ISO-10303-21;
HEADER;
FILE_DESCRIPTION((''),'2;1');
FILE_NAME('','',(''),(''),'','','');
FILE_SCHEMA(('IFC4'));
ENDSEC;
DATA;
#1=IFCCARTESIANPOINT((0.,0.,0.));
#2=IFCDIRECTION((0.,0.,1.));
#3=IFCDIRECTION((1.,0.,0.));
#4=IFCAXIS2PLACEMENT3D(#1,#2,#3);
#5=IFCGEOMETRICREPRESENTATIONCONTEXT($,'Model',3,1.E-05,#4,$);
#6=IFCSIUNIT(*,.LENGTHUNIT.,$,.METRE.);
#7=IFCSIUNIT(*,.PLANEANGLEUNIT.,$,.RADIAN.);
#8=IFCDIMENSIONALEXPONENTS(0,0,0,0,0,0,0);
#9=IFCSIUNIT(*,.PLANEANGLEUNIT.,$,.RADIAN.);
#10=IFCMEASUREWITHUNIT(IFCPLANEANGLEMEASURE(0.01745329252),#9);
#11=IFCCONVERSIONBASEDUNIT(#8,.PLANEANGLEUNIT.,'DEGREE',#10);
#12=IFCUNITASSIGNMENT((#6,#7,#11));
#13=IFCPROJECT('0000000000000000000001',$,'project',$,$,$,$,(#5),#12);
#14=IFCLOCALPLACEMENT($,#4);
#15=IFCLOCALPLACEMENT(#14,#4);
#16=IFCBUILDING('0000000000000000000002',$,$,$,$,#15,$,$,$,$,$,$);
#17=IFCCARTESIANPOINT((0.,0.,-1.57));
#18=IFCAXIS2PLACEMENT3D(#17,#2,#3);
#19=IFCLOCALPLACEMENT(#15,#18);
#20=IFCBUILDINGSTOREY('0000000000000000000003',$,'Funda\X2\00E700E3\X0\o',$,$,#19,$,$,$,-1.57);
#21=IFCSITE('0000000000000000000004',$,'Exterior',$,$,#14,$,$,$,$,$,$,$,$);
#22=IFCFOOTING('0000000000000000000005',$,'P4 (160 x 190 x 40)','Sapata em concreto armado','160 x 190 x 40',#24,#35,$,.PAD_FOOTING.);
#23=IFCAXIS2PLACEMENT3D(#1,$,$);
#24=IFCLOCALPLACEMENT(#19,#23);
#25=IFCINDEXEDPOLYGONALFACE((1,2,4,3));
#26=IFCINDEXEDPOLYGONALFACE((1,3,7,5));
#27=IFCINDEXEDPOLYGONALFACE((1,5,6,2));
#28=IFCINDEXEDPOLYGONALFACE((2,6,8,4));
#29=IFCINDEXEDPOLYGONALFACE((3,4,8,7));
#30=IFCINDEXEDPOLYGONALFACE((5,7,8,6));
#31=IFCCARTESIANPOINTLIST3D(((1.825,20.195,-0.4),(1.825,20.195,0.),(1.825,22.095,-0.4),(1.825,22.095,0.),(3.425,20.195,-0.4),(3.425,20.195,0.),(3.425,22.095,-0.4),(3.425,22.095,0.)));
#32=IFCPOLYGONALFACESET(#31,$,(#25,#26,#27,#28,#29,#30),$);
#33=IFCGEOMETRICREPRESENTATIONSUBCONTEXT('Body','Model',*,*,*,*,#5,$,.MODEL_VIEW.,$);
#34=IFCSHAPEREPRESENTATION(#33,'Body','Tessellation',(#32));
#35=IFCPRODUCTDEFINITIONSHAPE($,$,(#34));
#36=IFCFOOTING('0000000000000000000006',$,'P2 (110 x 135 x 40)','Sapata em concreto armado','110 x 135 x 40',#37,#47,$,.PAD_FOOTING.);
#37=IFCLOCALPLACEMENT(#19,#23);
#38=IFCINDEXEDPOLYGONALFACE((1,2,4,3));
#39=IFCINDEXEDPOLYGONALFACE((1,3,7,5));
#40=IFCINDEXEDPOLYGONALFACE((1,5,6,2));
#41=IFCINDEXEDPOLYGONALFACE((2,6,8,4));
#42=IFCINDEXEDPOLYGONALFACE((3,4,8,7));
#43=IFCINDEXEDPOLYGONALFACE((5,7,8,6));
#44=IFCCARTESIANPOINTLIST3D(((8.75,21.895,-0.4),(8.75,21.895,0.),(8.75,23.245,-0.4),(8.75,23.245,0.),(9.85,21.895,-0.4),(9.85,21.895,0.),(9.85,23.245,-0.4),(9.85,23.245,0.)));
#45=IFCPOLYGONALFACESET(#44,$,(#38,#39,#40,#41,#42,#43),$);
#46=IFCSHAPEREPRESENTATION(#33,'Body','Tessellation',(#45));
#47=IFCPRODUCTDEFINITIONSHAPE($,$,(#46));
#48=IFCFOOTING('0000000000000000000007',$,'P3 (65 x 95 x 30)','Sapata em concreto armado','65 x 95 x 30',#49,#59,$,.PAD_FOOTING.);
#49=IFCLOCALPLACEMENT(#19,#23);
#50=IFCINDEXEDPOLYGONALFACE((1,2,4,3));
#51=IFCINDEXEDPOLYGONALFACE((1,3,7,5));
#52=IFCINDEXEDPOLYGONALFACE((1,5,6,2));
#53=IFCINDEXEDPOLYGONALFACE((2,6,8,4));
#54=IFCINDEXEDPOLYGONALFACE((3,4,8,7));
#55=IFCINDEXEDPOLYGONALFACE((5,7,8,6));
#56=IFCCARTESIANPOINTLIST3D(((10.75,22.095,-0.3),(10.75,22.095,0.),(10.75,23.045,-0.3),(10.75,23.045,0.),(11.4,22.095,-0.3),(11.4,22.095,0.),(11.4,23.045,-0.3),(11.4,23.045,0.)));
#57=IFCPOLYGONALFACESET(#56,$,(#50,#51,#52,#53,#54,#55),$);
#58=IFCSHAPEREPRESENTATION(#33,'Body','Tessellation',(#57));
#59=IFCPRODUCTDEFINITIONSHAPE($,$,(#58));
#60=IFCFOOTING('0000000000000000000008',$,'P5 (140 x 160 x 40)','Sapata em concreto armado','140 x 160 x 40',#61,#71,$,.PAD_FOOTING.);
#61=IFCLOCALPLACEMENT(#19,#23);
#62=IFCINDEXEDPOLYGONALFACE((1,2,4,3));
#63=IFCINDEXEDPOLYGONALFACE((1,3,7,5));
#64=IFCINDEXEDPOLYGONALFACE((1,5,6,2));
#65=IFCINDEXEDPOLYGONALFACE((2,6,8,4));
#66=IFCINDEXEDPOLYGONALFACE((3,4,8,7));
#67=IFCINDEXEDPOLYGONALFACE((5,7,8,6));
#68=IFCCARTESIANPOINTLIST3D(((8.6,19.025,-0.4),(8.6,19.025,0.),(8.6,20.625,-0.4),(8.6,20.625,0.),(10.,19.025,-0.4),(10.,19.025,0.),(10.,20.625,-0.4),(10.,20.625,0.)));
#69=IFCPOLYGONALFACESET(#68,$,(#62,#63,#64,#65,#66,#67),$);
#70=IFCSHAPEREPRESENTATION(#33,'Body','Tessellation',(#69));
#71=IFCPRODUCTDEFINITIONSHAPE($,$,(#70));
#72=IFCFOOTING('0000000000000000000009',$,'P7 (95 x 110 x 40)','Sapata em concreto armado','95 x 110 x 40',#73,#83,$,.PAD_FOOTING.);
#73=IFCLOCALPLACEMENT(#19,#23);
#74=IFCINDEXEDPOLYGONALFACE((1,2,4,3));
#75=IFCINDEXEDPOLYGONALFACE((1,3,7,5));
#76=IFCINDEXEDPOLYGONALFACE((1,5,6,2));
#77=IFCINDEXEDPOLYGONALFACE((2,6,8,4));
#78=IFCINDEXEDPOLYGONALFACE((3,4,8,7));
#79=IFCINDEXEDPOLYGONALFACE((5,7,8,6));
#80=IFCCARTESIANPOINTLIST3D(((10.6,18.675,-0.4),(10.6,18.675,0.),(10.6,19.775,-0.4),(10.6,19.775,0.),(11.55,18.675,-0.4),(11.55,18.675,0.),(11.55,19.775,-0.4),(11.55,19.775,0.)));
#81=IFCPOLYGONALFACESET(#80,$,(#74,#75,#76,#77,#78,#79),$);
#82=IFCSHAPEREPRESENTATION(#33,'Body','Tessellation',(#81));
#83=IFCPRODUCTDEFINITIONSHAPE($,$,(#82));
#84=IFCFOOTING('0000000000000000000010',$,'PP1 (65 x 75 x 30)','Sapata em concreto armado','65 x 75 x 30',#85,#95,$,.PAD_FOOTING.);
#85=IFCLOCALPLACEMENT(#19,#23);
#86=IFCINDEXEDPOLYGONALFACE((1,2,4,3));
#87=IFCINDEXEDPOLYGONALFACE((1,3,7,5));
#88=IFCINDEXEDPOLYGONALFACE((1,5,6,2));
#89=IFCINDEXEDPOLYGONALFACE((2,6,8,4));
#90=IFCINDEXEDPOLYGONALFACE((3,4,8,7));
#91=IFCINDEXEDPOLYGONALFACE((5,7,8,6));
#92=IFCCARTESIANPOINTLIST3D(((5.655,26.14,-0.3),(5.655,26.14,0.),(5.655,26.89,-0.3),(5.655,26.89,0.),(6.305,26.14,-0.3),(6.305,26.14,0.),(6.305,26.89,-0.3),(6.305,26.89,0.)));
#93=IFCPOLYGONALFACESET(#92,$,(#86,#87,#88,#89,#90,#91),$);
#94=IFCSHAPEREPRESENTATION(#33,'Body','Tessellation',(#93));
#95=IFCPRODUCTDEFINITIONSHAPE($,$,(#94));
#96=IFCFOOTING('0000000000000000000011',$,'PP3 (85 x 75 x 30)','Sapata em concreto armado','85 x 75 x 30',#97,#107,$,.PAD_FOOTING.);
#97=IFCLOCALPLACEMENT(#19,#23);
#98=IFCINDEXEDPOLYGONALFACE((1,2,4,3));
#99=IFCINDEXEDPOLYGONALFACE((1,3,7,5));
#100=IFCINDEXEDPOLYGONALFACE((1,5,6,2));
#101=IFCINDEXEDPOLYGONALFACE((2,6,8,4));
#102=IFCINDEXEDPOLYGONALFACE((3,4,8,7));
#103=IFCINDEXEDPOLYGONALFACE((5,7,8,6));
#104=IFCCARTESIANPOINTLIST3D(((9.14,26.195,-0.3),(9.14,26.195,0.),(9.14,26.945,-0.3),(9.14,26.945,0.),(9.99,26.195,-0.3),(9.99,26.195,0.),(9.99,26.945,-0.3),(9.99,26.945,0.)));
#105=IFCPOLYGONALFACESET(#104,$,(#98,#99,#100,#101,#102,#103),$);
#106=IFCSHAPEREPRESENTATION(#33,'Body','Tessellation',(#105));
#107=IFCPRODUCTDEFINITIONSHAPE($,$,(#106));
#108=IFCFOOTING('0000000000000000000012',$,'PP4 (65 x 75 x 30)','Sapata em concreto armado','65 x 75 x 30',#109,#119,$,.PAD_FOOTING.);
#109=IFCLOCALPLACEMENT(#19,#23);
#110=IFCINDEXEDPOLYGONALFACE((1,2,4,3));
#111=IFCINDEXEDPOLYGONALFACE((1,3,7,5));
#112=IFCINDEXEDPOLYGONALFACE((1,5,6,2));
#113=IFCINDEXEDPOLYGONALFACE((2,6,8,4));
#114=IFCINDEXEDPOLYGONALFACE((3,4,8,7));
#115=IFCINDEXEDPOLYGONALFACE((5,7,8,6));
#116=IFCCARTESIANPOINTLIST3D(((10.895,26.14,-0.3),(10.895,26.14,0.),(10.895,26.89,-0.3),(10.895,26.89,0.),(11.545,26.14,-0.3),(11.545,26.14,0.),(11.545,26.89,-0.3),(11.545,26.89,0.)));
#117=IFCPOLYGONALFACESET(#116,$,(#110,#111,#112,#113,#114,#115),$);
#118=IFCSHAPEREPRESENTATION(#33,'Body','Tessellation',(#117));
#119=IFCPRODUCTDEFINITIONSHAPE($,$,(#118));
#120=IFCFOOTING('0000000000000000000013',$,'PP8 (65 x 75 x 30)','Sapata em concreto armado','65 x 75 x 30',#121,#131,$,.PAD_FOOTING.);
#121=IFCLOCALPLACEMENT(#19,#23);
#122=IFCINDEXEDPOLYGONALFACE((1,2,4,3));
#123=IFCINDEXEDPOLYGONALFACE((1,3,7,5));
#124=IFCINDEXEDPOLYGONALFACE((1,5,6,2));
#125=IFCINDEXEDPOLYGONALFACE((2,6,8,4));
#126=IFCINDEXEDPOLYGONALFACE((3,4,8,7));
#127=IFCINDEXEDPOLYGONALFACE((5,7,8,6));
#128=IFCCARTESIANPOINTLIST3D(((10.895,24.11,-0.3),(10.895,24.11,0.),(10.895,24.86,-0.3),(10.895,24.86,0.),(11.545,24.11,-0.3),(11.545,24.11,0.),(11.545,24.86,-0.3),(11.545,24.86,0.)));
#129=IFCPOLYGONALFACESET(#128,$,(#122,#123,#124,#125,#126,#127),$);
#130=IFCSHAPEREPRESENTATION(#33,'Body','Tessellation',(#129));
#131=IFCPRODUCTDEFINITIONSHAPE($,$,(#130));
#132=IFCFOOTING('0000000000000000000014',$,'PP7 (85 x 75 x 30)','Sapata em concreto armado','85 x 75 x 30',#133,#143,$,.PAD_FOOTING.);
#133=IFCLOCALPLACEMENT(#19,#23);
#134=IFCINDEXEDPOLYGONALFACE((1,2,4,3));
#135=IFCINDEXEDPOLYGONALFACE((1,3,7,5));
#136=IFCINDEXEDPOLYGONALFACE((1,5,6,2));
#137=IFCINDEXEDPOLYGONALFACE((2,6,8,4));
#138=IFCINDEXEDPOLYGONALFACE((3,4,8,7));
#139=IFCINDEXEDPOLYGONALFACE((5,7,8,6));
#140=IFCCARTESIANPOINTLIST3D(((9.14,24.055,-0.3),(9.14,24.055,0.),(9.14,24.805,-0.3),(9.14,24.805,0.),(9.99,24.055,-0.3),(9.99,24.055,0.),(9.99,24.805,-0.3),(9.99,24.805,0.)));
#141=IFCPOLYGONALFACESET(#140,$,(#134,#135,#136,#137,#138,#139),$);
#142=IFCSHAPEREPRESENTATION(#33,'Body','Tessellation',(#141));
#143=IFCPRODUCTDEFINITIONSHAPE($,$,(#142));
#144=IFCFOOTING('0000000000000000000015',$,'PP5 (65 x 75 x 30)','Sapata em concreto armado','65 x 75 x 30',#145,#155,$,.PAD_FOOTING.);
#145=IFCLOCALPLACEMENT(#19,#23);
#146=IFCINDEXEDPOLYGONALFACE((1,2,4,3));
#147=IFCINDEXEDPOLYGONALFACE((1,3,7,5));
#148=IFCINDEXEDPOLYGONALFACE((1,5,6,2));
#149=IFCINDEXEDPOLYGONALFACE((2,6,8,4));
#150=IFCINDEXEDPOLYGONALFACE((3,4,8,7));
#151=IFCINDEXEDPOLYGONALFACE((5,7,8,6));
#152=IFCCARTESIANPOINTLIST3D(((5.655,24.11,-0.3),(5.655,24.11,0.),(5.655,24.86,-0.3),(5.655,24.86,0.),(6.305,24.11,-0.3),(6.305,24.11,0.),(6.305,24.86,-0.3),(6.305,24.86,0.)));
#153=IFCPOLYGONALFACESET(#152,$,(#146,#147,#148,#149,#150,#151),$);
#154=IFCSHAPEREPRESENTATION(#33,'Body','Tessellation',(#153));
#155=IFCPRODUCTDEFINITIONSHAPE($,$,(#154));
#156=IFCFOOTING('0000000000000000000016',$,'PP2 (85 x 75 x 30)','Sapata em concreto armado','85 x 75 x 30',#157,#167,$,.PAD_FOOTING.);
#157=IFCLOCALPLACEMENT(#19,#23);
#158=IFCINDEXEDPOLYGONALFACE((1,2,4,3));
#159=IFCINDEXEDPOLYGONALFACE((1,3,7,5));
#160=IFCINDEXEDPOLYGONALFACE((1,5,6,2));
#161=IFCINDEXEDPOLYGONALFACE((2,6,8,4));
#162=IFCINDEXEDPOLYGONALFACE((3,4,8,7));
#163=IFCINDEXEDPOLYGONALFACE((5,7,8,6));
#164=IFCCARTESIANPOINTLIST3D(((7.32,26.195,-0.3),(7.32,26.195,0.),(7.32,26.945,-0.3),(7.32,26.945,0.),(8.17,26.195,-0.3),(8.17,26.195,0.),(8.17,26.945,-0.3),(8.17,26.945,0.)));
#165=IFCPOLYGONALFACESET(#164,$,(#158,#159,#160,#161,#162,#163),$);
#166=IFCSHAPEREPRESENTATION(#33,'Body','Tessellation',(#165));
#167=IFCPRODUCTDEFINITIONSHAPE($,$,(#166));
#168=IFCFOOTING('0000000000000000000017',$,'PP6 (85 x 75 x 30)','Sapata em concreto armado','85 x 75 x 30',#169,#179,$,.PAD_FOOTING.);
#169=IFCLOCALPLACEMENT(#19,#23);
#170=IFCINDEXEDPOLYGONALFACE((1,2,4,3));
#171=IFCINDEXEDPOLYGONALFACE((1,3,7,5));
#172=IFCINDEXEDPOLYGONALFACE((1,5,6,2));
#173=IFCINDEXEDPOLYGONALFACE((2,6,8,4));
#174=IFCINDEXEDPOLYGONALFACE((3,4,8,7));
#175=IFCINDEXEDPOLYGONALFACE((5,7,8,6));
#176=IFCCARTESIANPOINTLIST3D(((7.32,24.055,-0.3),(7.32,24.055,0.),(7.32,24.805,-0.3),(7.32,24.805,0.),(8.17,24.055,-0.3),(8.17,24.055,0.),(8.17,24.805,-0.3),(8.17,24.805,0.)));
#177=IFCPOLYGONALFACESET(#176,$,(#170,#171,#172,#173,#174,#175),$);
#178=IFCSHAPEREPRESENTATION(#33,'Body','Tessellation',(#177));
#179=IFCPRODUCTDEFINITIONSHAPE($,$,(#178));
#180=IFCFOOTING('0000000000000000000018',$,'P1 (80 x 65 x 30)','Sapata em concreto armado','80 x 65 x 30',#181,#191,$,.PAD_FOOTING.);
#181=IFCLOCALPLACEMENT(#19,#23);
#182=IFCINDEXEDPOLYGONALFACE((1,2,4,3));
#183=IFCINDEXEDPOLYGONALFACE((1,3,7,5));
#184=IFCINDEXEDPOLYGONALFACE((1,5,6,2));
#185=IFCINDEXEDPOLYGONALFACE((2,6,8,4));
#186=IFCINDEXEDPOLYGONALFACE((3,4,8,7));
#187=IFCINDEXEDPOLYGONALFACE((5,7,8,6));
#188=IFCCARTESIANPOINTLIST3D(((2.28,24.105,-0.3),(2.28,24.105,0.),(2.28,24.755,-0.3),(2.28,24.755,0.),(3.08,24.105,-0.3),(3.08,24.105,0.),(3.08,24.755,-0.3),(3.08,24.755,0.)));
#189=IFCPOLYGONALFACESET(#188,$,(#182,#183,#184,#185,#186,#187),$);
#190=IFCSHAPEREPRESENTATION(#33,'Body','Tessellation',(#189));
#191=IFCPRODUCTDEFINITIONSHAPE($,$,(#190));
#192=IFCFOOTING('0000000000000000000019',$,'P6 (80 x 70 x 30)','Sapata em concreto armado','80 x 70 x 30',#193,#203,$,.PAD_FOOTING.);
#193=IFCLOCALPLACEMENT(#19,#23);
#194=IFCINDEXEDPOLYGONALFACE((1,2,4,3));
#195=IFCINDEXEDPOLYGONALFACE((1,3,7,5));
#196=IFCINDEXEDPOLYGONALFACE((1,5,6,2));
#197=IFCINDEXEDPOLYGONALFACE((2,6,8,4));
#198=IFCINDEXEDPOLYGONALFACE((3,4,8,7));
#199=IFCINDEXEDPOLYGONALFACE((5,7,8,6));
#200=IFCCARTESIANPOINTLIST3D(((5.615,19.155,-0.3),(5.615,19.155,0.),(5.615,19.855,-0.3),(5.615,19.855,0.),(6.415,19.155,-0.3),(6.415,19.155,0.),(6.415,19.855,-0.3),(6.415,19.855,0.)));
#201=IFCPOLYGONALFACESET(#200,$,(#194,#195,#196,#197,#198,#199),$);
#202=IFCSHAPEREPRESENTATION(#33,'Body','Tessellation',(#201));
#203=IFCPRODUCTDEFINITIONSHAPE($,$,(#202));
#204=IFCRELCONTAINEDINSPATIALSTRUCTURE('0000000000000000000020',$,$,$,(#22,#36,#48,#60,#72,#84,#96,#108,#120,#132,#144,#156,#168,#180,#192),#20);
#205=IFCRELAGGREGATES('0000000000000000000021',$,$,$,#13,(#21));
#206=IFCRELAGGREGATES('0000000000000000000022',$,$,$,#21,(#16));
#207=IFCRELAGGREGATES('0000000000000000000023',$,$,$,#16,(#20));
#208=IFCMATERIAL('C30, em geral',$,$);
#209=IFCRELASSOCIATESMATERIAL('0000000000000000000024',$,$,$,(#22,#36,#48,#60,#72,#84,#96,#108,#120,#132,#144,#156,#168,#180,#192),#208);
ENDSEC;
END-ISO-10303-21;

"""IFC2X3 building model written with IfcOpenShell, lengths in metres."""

from ifc_helpers import new_model, entity, si_unit, converted_unit, frame, origin_with_axes, origin_2d_with_axis, place, context, subcontext, project, spatial, rectangle, extrude, material, element, save


model = new_model("IFC2X3")

# Units and contexts
model_context = context("Model", 3, precision=1e-05, world=origin_with_axes())
body_context = subcontext(model_context, "Body", "Model", "MODEL_VIEW")
ifc_project = project(units=[si_unit("LENGTHUNIT", "METRE"), si_unit("PLANEANGLEUNIT", "RADIAN"), converted_unit("PLANEANGLEUNIT", "DEGREE", entity("IfcPlaneAngleMeasure", 0.01745329252), si_unit("PLANEANGLEUNIT", "RADIAN"), dimensions=[0, 0, 0, 0, 0, 0, 0])], contexts=[model_context])

# Site, building, storey
site_placement = place(None, origin_with_axes())
site = spatial("IfcSite", under=ifc_project, at=site_placement, Name="Exterior")
building_placement = place(site_placement, origin_with_axes())
building = spatial("IfcBuilding", under=site, at=building_placement)
storey_placement = place(building_placement, frame((0.0, 0.0, -1.57), z_axis=(0.0, 0.0, 1.0), x_axis=(1.0, 0.0, 0.0)))
storey = spatial("IfcBuildingStorey", under=building, at=storey_placement, Name="Fundação", Elevation=-1.57)

# Footings
ifc_material_1 = material(Name="C30, em geral")
footing_1_placement = place(storey_placement, frame((2.625, 21.145, -0.4), z_axis=(0.0, 0.0, 1.0), x_axis=(1.0, 0.0, 0.0)))
element("IfcFooting", 1, at=footing_1_placement, inside=storey, material=ifc_material_1, Name="P4 (160 x 190 x 40)", Description="Sapata em concreto armado", ObjectType="160 x 190 x 40", PredefinedType="PAD_FOOTING", context=body_context, shape_type="SweptSolid", body=[
    extrude(rectangle(XDim=1.6, YDim=1.9, at=origin_2d_with_axis()), origin_with_axes(), (0.0, 0.0, 1.0), 0.4),
])
footing_2_placement = place(storey_placement, frame((9.3, 22.57, -0.4), z_axis=(0.0, 0.0, 1.0), x_axis=(1.0, 0.0, 0.0)))
element("IfcFooting", 2, at=footing_2_placement, inside=storey, material=ifc_material_1, Name="P2 (110 x 135 x 40)", Description="Sapata em concreto armado", ObjectType="110 x 135 x 40", PredefinedType="PAD_FOOTING", context=body_context, shape_type="SweptSolid", body=[
    extrude(rectangle(XDim=1.1, YDim=1.35, at=origin_2d_with_axis()), origin_with_axes(), (0.0, 0.0, 1.0), 0.4),
])
footing_3_placement = place(storey_placement, frame((11.075, 22.57, -0.3), z_axis=(0.0, 0.0, 1.0), x_axis=(1.0, 0.0, 0.0)))
element("IfcFooting", 3, at=footing_3_placement, inside=storey, material=ifc_material_1, Name="P3 (65 x 95 x 30)", Description="Sapata em concreto armado", ObjectType="65 x 95 x 30", PredefinedType="PAD_FOOTING", context=body_context, shape_type="SweptSolid", body=[
    extrude(rectangle(XDim=0.65, YDim=0.95, at=origin_2d_with_axis()), origin_with_axes(), (0.0, 0.0, 1.0), 0.3),
])
footing_4_placement = place(storey_placement, frame((9.3, 19.825, -0.4), z_axis=(0.0, 0.0, 1.0), x_axis=(1.0, 0.0, 0.0)))
element("IfcFooting", 4, at=footing_4_placement, inside=storey, material=ifc_material_1, Name="P5 (140 x 160 x 40)", Description="Sapata em concreto armado", ObjectType="140 x 160 x 40", PredefinedType="PAD_FOOTING", context=body_context, shape_type="SweptSolid", body=[
    extrude(rectangle(XDim=1.4, YDim=1.6, at=origin_2d_with_axis()), origin_with_axes(), (0.0, 0.0, 1.0), 0.4),
])
footing_5_placement = place(storey_placement, frame((11.075, 19.225, -0.4), z_axis=(0.0, 0.0, 1.0), x_axis=(1.0, 0.0, 0.0)))
element("IfcFooting", 5, at=footing_5_placement, inside=storey, material=ifc_material_1, Name="P7 (95 x 110 x 40)", Description="Sapata em concreto armado", ObjectType="95 x 110 x 40", PredefinedType="PAD_FOOTING", context=body_context, shape_type="SweptSolid", body=[
    extrude(rectangle(XDim=0.95, YDim=1.1, at=origin_2d_with_axis()), origin_with_axes(), (0.0, 0.0, 1.0), 0.4),
])
footing_6_placement = place(storey_placement, frame((5.98, 26.515, -0.3), z_axis=(0.0, 0.0, 1.0), x_axis=(1.0, 0.0, 0.0)))
element("IfcFooting", 6, at=footing_6_placement, inside=storey, material=ifc_material_1, Name="PP1 (65 x 75 x 30)", Description="Sapata em concreto armado", ObjectType="65 x 75 x 30", PredefinedType="PAD_FOOTING", context=body_context, shape_type="SweptSolid", body=[
    extrude(rectangle(XDim=0.65, YDim=0.75, at=origin_2d_with_axis()), origin_with_axes(), (0.0, 0.0, 1.0), 0.3),
])
footing_7_placement = place(storey_placement, frame((9.565, 26.57, -0.3), z_axis=(0.0, 0.0, 1.0), x_axis=(1.0, 0.0, 0.0)))
element("IfcFooting", 7, at=footing_7_placement, inside=storey, material=ifc_material_1, Name="PP3 (85 x 75 x 30)", Description="Sapata em concreto armado", ObjectType="85 x 75 x 30", PredefinedType="PAD_FOOTING", context=body_context, shape_type="SweptSolid", body=[
    extrude(rectangle(XDim=0.85, YDim=0.75, at=origin_2d_with_axis()), origin_with_axes(), (0.0, 0.0, 1.0), 0.3),
])
for number, where, z_axis, x_axis, name in (
    (8, (11.22, 26.515, -0.3), (0.0, 0.0, 1.0), (1.0, 0.0, 0.0), "PP4 (65 x 75 x 30)"),
    (9, (11.22, 24.485, -0.3), (0.0, 0.0, 1.0), (1.0, 0.0, 0.0), "PP8 (65 x 75 x 30)"),
):
    element("IfcFooting", number, at=place(storey_placement, frame(where, z_axis=z_axis, x_axis=x_axis)), inside=storey, material=ifc_material_1, Name=name, Description="Sapata em concreto armado", ObjectType="65 x 75 x 30", PredefinedType="PAD_FOOTING", context=body_context, shape_type="SweptSolid", body=[
        extrude(rectangle(XDim=0.65, YDim=0.75, at=origin_2d_with_axis()), origin_with_axes(), (0.0, 0.0, 1.0), 0.3),
    ])
footing_8_placement = place(storey_placement, frame((9.565, 24.43, -0.3), z_axis=(0.0, 0.0, 1.0), x_axis=(1.0, 0.0, 0.0)))
element("IfcFooting", 10, at=footing_8_placement, inside=storey, material=ifc_material_1, Name="PP7 (85 x 75 x 30)", Description="Sapata em concreto armado", ObjectType="85 x 75 x 30", PredefinedType="PAD_FOOTING", context=body_context, shape_type="SweptSolid", body=[
    extrude(rectangle(XDim=0.85, YDim=0.75, at=origin_2d_with_axis()), origin_with_axes(), (0.0, 0.0, 1.0), 0.3),
])
footing_9_placement = place(storey_placement, frame((5.98, 24.485, -0.3), z_axis=(0.0, 0.0, 1.0), x_axis=(1.0, 0.0, 0.0)))
element("IfcFooting", 11, at=footing_9_placement, inside=storey, material=ifc_material_1, Name="PP5 (65 x 75 x 30)", Description="Sapata em concreto armado", ObjectType="65 x 75 x 30", PredefinedType="PAD_FOOTING", context=body_context, shape_type="SweptSolid", body=[
    extrude(rectangle(XDim=0.65, YDim=0.75, at=origin_2d_with_axis()), origin_with_axes(), (0.0, 0.0, 1.0), 0.3),
])
for number, where, z_axis, x_axis, name in (
    (12, (7.745, 26.57, -0.3), (0.0, 0.0, 1.0), (1.0, 0.0, 0.0), "PP2 (85 x 75 x 30)"),
    (13, (7.745, 24.43, -0.3), (0.0, 0.0, 1.0), (1.0, 0.0, 0.0), "PP6 (85 x 75 x 30)"),
):
    element("IfcFooting", number, at=place(storey_placement, frame(where, z_axis=z_axis, x_axis=x_axis)), inside=storey, material=ifc_material_1, Name=name, Description="Sapata em concreto armado", ObjectType="85 x 75 x 30", PredefinedType="PAD_FOOTING", context=body_context, shape_type="SweptSolid", body=[
        extrude(rectangle(XDim=0.85, YDim=0.75, at=origin_2d_with_axis()), origin_with_axes(), (0.0, 0.0, 1.0), 0.3),
    ])
footing_10_placement = place(storey_placement, frame((2.68, 24.43, -0.3), z_axis=(0.0, 0.0, 1.0), x_axis=(1.0, 0.0, 0.0)))
element("IfcFooting", 14, at=footing_10_placement, inside=storey, material=ifc_material_1, Name="P1 (80 x 65 x 30)", Description="Sapata em concreto armado", ObjectType="80 x 65 x 30", PredefinedType="PAD_FOOTING", context=body_context, shape_type="SweptSolid", body=[
    extrude(rectangle(XDim=0.8, YDim=0.65, at=origin_2d_with_axis()), origin_with_axes(), (0.0, 0.0, 1.0), 0.3),
])
footing_11_placement = place(storey_placement, frame((6.015, 19.505, -0.3), z_axis=(0.0, 0.0, 1.0), x_axis=(1.0, 0.0, 0.0)))
element("IfcFooting", 15, at=footing_11_placement, inside=storey, material=ifc_material_1, Name="P6 (80 x 70 x 30)", Description="Sapata em concreto armado", ObjectType="80 x 70 x 30", PredefinedType="PAD_FOOTING", context=body_context, shape_type="SweptSolid", body=[
    extrude(rectangle(XDim=0.8, YDim=0.7, at=origin_2d_with_axis()), origin_with_axes(), (0.0, 0.0, 1.0), 0.3),
])

save(model, "model.ifc")
